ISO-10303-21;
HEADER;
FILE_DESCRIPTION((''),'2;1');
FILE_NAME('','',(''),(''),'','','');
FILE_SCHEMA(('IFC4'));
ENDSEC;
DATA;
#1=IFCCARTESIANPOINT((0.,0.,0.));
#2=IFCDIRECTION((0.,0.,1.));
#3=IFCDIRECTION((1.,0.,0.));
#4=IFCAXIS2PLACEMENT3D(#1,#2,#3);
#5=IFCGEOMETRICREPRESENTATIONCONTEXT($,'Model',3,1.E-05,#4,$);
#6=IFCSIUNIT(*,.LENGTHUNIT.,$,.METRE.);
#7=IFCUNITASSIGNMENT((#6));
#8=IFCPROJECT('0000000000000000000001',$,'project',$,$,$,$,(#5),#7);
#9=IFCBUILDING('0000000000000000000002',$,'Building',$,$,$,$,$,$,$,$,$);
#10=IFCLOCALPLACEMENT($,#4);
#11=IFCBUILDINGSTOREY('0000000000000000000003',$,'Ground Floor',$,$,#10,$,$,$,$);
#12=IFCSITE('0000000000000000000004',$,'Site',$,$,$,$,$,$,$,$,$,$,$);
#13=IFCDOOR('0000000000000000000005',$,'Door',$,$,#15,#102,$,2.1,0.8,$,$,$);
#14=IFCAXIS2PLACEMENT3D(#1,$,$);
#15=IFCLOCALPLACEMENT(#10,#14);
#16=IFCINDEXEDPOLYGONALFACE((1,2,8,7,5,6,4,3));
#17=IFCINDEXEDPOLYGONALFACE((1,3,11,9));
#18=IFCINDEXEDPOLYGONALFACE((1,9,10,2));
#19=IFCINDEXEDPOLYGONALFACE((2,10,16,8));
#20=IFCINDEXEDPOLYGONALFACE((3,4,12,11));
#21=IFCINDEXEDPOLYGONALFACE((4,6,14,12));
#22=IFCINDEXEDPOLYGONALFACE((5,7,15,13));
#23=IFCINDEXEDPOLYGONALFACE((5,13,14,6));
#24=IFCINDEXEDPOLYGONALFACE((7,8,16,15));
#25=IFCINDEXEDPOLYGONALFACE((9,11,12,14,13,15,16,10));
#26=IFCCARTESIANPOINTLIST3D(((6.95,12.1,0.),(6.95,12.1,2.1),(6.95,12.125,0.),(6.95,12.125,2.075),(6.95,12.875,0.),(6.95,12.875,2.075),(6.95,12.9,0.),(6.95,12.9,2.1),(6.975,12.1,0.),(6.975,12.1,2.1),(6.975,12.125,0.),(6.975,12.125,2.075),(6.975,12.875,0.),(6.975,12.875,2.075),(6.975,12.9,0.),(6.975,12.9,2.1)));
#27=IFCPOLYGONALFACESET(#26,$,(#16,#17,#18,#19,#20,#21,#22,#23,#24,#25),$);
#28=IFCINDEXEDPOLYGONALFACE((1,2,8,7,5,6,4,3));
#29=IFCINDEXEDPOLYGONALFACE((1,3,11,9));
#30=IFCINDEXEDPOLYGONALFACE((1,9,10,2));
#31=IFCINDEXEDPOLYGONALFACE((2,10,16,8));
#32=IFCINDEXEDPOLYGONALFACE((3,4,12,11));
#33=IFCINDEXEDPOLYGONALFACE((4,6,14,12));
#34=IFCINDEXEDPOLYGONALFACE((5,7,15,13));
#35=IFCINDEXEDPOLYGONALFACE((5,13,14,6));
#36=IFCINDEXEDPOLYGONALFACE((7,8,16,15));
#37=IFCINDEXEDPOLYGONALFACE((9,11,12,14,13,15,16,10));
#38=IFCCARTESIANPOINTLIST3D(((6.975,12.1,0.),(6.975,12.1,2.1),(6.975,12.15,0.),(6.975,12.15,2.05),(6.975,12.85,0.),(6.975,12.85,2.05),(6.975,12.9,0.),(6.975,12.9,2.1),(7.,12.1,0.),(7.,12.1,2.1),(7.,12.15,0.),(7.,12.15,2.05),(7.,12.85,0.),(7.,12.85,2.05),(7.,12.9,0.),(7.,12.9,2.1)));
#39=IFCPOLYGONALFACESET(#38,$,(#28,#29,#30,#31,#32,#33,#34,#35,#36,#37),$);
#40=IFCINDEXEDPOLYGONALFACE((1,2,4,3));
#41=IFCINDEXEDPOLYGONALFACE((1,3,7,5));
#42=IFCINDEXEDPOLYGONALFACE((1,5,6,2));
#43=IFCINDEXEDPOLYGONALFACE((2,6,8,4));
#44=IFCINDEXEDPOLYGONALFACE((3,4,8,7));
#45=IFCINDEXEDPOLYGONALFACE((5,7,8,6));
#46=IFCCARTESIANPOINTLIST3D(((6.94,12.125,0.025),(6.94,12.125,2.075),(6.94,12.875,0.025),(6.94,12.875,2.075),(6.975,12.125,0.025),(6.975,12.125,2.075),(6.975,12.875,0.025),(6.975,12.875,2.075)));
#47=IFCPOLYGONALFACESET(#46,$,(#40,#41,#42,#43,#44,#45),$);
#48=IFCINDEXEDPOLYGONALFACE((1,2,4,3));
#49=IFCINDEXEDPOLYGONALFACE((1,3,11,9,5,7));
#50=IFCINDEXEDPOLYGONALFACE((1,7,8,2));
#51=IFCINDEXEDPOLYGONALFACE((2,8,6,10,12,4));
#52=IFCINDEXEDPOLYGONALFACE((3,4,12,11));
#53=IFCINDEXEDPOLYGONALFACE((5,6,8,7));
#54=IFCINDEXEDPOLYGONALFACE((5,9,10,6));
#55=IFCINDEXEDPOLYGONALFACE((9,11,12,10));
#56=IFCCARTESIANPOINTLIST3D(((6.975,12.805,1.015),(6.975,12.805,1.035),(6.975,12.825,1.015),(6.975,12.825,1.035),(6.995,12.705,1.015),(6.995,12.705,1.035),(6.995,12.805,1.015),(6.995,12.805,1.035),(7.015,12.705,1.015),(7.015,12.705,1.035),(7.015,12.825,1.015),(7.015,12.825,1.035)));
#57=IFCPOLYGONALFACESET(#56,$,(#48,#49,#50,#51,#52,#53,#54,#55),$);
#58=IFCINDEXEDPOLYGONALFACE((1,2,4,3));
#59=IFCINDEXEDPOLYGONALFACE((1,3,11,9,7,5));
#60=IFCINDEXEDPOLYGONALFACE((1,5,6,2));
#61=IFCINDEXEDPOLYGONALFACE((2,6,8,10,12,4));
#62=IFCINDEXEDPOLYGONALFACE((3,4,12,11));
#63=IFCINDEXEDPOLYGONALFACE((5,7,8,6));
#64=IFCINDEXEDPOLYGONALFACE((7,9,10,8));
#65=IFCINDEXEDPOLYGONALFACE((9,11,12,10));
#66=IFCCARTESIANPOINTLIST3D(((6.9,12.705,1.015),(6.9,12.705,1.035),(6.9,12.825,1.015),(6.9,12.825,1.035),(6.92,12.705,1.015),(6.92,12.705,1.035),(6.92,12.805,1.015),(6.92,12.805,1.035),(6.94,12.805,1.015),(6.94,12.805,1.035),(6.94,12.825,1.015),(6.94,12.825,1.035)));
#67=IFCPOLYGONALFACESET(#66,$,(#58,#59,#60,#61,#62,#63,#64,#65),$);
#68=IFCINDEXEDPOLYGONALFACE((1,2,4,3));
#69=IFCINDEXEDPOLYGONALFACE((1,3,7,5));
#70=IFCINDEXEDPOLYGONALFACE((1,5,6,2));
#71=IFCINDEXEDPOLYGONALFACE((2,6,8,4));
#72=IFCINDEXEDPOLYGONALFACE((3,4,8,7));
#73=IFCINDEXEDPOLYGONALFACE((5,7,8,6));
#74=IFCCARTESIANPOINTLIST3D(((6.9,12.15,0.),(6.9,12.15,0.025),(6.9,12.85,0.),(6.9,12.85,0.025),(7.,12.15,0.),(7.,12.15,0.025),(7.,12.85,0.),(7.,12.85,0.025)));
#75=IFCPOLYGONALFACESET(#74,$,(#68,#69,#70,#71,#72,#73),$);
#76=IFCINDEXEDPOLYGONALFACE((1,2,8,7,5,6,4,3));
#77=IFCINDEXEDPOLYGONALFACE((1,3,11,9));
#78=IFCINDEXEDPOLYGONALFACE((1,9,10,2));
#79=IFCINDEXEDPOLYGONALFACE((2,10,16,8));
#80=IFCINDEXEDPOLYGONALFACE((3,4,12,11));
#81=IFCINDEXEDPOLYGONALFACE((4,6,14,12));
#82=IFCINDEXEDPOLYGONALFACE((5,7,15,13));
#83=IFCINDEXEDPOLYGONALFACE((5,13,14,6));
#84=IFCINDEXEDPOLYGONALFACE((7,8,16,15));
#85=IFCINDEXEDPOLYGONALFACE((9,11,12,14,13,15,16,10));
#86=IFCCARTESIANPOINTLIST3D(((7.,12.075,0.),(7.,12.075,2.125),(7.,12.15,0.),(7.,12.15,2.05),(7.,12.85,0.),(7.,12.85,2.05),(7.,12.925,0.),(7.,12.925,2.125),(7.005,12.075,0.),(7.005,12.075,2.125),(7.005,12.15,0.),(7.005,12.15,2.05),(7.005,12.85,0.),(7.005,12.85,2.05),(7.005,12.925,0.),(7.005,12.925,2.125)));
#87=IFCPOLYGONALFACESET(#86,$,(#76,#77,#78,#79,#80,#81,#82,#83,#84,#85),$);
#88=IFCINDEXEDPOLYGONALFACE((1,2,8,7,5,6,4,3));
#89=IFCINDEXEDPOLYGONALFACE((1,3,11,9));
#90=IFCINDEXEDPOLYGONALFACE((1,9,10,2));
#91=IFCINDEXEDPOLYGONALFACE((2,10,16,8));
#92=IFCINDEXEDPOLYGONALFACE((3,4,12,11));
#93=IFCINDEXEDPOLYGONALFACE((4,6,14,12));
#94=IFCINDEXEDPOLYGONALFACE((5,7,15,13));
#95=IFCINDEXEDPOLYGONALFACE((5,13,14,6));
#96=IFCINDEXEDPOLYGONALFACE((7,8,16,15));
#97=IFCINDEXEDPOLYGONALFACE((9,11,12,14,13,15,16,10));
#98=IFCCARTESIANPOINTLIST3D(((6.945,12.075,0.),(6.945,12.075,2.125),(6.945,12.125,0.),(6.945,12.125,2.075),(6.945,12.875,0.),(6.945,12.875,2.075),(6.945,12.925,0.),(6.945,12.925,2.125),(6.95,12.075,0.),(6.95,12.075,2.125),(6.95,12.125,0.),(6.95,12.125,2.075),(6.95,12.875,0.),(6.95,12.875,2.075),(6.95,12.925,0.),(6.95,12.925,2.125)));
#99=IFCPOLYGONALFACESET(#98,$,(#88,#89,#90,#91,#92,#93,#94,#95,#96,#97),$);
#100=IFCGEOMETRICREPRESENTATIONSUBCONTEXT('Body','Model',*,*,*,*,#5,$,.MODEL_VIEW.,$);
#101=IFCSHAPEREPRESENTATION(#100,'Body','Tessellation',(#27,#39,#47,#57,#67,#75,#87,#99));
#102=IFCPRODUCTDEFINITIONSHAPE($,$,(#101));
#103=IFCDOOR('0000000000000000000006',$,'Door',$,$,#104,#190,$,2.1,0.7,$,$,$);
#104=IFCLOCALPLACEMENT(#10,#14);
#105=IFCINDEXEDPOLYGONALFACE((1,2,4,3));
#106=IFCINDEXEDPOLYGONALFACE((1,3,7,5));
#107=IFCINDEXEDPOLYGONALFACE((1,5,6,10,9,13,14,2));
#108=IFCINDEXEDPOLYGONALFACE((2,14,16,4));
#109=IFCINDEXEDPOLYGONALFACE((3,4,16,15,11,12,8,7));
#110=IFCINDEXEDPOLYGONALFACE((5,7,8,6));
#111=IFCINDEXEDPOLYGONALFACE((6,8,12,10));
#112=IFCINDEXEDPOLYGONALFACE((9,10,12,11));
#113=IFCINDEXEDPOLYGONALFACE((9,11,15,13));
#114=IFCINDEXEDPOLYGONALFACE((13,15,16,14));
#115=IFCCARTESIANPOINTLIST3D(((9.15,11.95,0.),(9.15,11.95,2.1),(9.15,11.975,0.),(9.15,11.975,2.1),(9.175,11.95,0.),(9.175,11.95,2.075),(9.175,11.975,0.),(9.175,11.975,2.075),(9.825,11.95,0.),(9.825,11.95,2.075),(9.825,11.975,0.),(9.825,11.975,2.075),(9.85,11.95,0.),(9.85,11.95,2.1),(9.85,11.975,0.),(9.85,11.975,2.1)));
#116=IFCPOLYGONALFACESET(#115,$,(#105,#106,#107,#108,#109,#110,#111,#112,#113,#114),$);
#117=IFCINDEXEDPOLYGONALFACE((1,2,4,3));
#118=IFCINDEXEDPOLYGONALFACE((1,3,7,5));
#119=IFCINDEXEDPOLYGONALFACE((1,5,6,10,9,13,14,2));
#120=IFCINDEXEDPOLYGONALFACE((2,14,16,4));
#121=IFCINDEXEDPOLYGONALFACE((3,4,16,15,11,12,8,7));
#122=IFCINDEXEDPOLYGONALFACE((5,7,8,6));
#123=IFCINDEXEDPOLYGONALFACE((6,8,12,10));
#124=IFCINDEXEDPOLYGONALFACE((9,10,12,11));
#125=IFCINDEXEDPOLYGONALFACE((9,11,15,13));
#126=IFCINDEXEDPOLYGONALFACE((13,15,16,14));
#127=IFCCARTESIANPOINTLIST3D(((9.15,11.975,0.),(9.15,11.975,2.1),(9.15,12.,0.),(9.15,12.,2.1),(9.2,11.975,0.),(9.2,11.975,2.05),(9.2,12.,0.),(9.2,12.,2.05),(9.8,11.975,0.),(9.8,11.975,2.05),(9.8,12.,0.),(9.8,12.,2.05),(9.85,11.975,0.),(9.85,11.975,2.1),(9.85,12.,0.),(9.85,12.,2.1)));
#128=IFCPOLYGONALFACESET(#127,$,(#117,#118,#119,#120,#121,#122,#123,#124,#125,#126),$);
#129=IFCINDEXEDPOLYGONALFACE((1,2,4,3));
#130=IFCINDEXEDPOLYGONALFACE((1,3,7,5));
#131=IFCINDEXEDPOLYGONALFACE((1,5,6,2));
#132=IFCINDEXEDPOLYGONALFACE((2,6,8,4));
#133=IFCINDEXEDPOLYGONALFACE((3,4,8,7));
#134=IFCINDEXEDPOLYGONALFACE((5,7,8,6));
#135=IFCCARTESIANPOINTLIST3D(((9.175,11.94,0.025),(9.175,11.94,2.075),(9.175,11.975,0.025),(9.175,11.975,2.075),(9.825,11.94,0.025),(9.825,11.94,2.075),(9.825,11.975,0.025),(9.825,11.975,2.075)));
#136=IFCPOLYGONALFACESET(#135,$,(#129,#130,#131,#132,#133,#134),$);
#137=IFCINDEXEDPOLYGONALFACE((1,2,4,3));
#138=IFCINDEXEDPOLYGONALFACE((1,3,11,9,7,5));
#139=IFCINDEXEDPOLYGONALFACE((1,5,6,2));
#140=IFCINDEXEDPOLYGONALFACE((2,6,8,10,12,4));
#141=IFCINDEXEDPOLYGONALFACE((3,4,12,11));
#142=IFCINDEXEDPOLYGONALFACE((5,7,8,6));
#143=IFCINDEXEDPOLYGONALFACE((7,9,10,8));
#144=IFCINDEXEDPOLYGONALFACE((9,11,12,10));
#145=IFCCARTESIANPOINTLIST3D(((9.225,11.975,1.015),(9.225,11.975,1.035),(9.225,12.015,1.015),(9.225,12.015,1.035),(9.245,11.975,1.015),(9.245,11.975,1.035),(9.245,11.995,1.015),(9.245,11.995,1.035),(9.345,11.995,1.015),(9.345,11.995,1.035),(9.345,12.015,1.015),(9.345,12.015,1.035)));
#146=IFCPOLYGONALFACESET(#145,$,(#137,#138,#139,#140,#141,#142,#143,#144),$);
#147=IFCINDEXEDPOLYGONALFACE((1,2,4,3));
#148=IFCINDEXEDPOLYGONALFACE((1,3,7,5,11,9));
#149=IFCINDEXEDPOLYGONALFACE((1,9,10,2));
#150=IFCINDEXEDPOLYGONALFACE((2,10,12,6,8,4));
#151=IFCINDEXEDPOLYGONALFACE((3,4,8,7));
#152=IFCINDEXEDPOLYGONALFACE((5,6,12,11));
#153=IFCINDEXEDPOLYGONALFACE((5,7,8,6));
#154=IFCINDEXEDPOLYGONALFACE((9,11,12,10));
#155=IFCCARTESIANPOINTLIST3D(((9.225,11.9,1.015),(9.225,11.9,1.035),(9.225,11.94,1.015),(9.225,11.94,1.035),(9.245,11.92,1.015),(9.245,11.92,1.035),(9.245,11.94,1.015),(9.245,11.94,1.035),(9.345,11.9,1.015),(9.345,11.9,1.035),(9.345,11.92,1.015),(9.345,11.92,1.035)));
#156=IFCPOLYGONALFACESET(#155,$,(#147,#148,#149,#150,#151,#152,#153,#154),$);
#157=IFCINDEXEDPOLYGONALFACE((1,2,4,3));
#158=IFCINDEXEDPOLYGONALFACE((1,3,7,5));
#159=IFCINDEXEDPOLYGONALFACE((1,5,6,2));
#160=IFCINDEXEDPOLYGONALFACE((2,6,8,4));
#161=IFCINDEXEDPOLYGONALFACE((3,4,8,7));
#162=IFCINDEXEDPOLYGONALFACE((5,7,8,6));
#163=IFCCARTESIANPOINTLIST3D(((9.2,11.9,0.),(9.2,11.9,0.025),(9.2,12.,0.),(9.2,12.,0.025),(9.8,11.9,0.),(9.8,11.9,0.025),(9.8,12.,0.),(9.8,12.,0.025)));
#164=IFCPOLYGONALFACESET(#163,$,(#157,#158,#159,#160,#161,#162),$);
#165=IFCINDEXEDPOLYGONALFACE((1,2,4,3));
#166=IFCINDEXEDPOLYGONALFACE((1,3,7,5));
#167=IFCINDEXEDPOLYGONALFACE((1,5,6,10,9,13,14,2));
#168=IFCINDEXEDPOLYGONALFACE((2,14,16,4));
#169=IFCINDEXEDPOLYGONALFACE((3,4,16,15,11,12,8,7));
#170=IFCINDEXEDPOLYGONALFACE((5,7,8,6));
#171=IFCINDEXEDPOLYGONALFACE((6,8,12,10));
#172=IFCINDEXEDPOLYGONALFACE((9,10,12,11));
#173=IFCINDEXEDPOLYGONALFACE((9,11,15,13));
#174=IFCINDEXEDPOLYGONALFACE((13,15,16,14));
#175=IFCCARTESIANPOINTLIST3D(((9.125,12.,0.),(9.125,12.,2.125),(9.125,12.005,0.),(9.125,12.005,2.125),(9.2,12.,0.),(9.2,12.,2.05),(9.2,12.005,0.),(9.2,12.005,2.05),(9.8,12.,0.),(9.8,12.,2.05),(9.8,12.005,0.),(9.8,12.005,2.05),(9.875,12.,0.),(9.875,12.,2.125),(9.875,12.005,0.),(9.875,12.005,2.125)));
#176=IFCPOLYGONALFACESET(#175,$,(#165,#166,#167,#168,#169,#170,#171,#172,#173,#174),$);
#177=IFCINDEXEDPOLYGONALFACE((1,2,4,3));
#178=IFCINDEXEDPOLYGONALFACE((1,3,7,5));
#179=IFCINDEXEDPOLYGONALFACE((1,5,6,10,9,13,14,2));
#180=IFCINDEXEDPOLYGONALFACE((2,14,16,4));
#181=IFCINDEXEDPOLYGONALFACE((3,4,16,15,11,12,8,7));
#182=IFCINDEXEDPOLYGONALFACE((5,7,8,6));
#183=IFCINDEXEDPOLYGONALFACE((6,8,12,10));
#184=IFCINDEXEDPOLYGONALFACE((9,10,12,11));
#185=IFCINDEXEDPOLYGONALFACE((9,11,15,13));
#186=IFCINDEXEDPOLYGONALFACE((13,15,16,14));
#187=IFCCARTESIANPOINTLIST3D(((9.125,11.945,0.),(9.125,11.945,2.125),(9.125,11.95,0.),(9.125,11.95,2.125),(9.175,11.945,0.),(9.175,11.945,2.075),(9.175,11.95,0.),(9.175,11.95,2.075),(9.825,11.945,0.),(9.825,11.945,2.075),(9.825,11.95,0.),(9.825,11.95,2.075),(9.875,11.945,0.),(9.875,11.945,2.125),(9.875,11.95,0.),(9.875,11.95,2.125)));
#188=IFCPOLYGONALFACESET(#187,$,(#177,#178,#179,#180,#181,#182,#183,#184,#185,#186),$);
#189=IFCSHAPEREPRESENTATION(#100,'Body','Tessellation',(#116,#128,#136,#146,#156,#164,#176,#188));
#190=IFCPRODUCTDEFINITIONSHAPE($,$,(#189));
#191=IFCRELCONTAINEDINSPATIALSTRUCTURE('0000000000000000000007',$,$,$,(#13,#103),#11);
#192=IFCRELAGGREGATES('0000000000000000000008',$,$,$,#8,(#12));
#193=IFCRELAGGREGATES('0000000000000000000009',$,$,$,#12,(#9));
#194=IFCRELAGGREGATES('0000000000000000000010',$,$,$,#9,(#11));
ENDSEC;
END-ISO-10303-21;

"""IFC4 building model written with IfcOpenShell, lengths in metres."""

from ifc_helpers import new_model, si_unit, frame, origin_with_axes, place, context, subcontext, project, spatial, line, indexed_curve, outline, extrude, element, save


model = new_model("IFC4")

# Units and contexts
model_context = context("Model", 3, precision=1e-05, world=origin_with_axes())
body_context = subcontext(model_context, "Body", "Model", "MODEL_VIEW")
ifc_project = project(units=[si_unit("LENGTHUNIT", "METRE")], contexts=[model_context])

# Site, building, storey
site = spatial("IfcSite", under=ifc_project, Name="Site")
building = spatial("IfcBuilding", under=site, Name="Building")
storey_placement = place(None, origin_with_axes())
storey = spatial("IfcBuildingStorey", under=building, at=storey_placement, Name="Ground Floor")

# Doors
door_1_placement = place(storey_placement, frame((7.0, 12.1, 0.0), z_axis=(0.0, 0.0, 1.0), x_axis=(0.0, 1.0, 0.0)))
element("IfcDoor", 1, at=door_1_placement, inside=storey, Name="Door", OverallHeight=2.1, OverallWidth=0.8, context=body_context, shape_type="SweptSolid", body=[
    extrude(outline(indexed_curve([(0.0, 0.0), (0.0, 2.1), (0.8, 2.1), (0.8, 0.0), (0.775, 0.0), (0.775, 2.075), (0.025, 2.075), (0.025, 0.0)], segments=[line(1, 2, 3, 4, 5, 6, 7, 8, 1)])), frame((0.0, 0.025, 0.0), z_axis=(0.0, -1.0, 0.0), x_axis=(1.0, 0.0, 0.0)), (0.0, 0.0, -1.0), 0.025),
    extrude(outline(indexed_curve([(0.0, 0.0), (0.0, 2.1), (0.8, 2.1), (0.8, 0.0), (0.75, 0.0), (0.75, 2.05), (0.05, 2.05), (0.05, 0.0)], segments=[line(1, 2, 3, 4, 5, 6, 7, 8, 1)])), frame((0.0, 0.0, 0.0), z_axis=(0.0, -1.0, 0.0), x_axis=(1.0, 0.0, 0.0)), (0.0, 0.0, -1.0), 0.025),
    extrude(outline(indexed_curve([(0.0, 0.0), (0.75, 0.0), (0.75, 0.035), (0.0, 0.035)], segments=[line(1, 2, 3, 4, 1)])), frame((0.025, 0.025, 0.025), z_axis=(0.0, 0.0, 1.0), x_axis=(1.0, 0.0, 0.0)), (0.0, 0.0, 1.0), 2.05),
    extrude(outline(indexed_curve([(0.0, 0.0), (0.0, -0.04), (-0.12, -0.04), (-0.12, -0.02), (-0.02, -0.02), (-0.02, 0.0)], segments=[line(1, 2, 3, 4, 5, 6, 1)])), frame((0.725, 0.025, 1.015), z_axis=(0.0, 0.0, 1.0), x_axis=(1.0, 0.0, 0.0)), (0.0, 0.0, 1.0), 0.02),
    extrude(outline(indexed_curve([(0.0, 0.0), (0.0, 0.04), (-0.12, 0.04), (-0.12, 0.02), (-0.02, 0.02), (-0.02, 0.0)], segments=[line(1, 2, 3, 4, 5, 6, 1)])), frame((0.725, 0.06, 1.015), z_axis=(0.0, 0.0, 1.0), x_axis=(1.0, 0.0, 0.0)), (0.0, 0.0, 1.0), 0.02),
    extrude(outline(indexed_curve([(0.0, 0.0), (0.7, 0.0), (0.7, 0.1), (0.0, 0.1)], segments=[line(1, 2, 3, 4, 1)])), frame((0.05, 0.0, 0.0), z_axis=(0.0, 0.0, 1.0), x_axis=(1.0, 0.0, 0.0)), (0.0, 0.0, 1.0), 0.025),
    extrude(outline(indexed_curve([(0.0, 0.0), (0.0, 2.125), (0.85, 2.125), (0.85, 0.0), (0.775, 0.0), (0.775, 2.05), (0.075, 2.05), (0.075, 0.0)], segments=[line(1, 2, 3, 4, 5, 6, 7, 8, 1)])), frame((-0.025, -0.005, 0.0), z_axis=(0.0, -1.0, 0.0), x_axis=(1.0, 0.0, 0.0)), (0.0, 0.0, -1.0), 0.005),
    extrude(outline(indexed_curve([(0.0, 0.0), (0.0, 2.125), (0.85, 2.125), (0.85, 0.0), (0.8, 0.0), (0.8, 2.075), (0.05, 2.075), (0.05, 0.0)], segments=[line(1, 2, 3, 4, 5, 6, 7, 8, 1)])), frame((-0.025, 0.05, 0.0), z_axis=(0.0, -1.0, 0.0), x_axis=(1.0, 0.0, 0.0)), (0.0, 0.0, -1.0), 0.005),
])
door_2_placement = place(storey_placement, frame((9.85, 12.0, 0.0), z_axis=(0.0, 0.0, 1.0), x_axis=(-1.0, 0.0, 0.0)))
element("IfcDoor", 2, at=door_2_placement, inside=storey, Name="Door", OverallHeight=2.1, OverallWidth=0.7, context=body_context, shape_type="SweptSolid", body=[
    extrude(outline(indexed_curve([(0.0, 0.0), (0.0, 2.1), (0.7, 2.1), (0.7, 0.0), (0.675, 0.0), (0.675, 2.075), (0.025, 2.075), (0.025, 0.0)], segments=[line(1, 2, 3, 4, 5, 6, 7, 8, 1)])), frame((0.0, 0.025, 0.0), z_axis=(0.0, -1.0, 0.0), x_axis=(1.0, 0.0, 0.0)), (0.0, 0.0, -1.0), 0.025),
    extrude(outline(indexed_curve([(0.0, 0.0), (0.0, 2.1), (0.7, 2.1), (0.7, 0.0), (0.65, 0.0), (0.65, 2.05), (0.05, 2.05), (0.05, 0.0)], segments=[line(1, 2, 3, 4, 5, 6, 7, 8, 1)])), frame((0.0, 0.0, 0.0), z_axis=(0.0, -1.0, 0.0), x_axis=(1.0, 0.0, 0.0)), (0.0, 0.0, -1.0), 0.025),
    extrude(outline(indexed_curve([(0.0, 0.0), (0.65, 0.0), (0.65, 0.035), (0.0, 0.035)], segments=[line(1, 2, 3, 4, 1)])), frame((0.025, 0.025, 0.025), z_axis=(0.0, 0.0, 1.0), x_axis=(1.0, 0.0, 0.0)), (0.0, 0.0, 1.0), 2.05),
    extrude(outline(indexed_curve([(0.0, 0.0), (0.0, -0.04), (-0.12, -0.04), (-0.12, -0.02), (-0.02, -0.02), (-0.02, 0.0)], segments=[line(1, 2, 3, 4, 5, 6, 1)])), frame((0.625, 0.025, 1.015), z_axis=(0.0, 0.0, 1.0), x_axis=(1.0, 0.0, 0.0)), (0.0, 0.0, 1.0), 0.02),
    extrude(outline(indexed_curve([(0.0, 0.0), (0.0, 0.04), (-0.12, 0.04), (-0.12, 0.02), (-0.02, 0.02), (-0.02, 0.0)], segments=[line(1, 2, 3, 4, 5, 6, 1)])), frame((0.625, 0.06, 1.015), z_axis=(0.0, 0.0, 1.0), x_axis=(1.0, 0.0, 0.0)), (0.0, 0.0, 1.0), 0.02),
    extrude(outline(indexed_curve([(0.0, 0.0), (0.6, 0.0), (0.6, 0.1), (0.0, 0.1)], segments=[line(1, 2, 3, 4, 1)])), frame((0.05, 0.0, 0.0), z_axis=(0.0, 0.0, 1.0), x_axis=(1.0, 0.0, 0.0)), (0.0, 0.0, 1.0), 0.025),
    extrude(outline(indexed_curve([(0.0, 0.0), (0.0, 2.125), (0.75, 2.125), (0.75, 0.0), (0.675, 0.0), (0.675, 2.05), (0.075, 2.05), (0.075, 0.0)], segments=[line(1, 2, 3, 4, 5, 6, 7, 8, 1)])), frame((-0.025, -0.005, 0.0), z_axis=(0.0, -1.0, 0.0), x_axis=(1.0, 0.0, 0.0)), (0.0, 0.0, -1.0), 0.005),
    extrude(outline(indexed_curve([(0.0, 0.0), (0.0, 2.125), (0.75, 2.125), (0.75, 0.0), (0.7, 0.0), (0.7, 2.075), (0.05, 2.075), (0.05, 0.0)], segments=[line(1, 2, 3, 4, 5, 6, 7, 8, 1)])), frame((-0.025, 0.05, 0.0), z_axis=(0.0, -1.0, 0.0), x_axis=(1.0, 0.0, 0.0)), (0.0, 0.0, -1.0), 0.005),
])

save(model, "model.ifc")
